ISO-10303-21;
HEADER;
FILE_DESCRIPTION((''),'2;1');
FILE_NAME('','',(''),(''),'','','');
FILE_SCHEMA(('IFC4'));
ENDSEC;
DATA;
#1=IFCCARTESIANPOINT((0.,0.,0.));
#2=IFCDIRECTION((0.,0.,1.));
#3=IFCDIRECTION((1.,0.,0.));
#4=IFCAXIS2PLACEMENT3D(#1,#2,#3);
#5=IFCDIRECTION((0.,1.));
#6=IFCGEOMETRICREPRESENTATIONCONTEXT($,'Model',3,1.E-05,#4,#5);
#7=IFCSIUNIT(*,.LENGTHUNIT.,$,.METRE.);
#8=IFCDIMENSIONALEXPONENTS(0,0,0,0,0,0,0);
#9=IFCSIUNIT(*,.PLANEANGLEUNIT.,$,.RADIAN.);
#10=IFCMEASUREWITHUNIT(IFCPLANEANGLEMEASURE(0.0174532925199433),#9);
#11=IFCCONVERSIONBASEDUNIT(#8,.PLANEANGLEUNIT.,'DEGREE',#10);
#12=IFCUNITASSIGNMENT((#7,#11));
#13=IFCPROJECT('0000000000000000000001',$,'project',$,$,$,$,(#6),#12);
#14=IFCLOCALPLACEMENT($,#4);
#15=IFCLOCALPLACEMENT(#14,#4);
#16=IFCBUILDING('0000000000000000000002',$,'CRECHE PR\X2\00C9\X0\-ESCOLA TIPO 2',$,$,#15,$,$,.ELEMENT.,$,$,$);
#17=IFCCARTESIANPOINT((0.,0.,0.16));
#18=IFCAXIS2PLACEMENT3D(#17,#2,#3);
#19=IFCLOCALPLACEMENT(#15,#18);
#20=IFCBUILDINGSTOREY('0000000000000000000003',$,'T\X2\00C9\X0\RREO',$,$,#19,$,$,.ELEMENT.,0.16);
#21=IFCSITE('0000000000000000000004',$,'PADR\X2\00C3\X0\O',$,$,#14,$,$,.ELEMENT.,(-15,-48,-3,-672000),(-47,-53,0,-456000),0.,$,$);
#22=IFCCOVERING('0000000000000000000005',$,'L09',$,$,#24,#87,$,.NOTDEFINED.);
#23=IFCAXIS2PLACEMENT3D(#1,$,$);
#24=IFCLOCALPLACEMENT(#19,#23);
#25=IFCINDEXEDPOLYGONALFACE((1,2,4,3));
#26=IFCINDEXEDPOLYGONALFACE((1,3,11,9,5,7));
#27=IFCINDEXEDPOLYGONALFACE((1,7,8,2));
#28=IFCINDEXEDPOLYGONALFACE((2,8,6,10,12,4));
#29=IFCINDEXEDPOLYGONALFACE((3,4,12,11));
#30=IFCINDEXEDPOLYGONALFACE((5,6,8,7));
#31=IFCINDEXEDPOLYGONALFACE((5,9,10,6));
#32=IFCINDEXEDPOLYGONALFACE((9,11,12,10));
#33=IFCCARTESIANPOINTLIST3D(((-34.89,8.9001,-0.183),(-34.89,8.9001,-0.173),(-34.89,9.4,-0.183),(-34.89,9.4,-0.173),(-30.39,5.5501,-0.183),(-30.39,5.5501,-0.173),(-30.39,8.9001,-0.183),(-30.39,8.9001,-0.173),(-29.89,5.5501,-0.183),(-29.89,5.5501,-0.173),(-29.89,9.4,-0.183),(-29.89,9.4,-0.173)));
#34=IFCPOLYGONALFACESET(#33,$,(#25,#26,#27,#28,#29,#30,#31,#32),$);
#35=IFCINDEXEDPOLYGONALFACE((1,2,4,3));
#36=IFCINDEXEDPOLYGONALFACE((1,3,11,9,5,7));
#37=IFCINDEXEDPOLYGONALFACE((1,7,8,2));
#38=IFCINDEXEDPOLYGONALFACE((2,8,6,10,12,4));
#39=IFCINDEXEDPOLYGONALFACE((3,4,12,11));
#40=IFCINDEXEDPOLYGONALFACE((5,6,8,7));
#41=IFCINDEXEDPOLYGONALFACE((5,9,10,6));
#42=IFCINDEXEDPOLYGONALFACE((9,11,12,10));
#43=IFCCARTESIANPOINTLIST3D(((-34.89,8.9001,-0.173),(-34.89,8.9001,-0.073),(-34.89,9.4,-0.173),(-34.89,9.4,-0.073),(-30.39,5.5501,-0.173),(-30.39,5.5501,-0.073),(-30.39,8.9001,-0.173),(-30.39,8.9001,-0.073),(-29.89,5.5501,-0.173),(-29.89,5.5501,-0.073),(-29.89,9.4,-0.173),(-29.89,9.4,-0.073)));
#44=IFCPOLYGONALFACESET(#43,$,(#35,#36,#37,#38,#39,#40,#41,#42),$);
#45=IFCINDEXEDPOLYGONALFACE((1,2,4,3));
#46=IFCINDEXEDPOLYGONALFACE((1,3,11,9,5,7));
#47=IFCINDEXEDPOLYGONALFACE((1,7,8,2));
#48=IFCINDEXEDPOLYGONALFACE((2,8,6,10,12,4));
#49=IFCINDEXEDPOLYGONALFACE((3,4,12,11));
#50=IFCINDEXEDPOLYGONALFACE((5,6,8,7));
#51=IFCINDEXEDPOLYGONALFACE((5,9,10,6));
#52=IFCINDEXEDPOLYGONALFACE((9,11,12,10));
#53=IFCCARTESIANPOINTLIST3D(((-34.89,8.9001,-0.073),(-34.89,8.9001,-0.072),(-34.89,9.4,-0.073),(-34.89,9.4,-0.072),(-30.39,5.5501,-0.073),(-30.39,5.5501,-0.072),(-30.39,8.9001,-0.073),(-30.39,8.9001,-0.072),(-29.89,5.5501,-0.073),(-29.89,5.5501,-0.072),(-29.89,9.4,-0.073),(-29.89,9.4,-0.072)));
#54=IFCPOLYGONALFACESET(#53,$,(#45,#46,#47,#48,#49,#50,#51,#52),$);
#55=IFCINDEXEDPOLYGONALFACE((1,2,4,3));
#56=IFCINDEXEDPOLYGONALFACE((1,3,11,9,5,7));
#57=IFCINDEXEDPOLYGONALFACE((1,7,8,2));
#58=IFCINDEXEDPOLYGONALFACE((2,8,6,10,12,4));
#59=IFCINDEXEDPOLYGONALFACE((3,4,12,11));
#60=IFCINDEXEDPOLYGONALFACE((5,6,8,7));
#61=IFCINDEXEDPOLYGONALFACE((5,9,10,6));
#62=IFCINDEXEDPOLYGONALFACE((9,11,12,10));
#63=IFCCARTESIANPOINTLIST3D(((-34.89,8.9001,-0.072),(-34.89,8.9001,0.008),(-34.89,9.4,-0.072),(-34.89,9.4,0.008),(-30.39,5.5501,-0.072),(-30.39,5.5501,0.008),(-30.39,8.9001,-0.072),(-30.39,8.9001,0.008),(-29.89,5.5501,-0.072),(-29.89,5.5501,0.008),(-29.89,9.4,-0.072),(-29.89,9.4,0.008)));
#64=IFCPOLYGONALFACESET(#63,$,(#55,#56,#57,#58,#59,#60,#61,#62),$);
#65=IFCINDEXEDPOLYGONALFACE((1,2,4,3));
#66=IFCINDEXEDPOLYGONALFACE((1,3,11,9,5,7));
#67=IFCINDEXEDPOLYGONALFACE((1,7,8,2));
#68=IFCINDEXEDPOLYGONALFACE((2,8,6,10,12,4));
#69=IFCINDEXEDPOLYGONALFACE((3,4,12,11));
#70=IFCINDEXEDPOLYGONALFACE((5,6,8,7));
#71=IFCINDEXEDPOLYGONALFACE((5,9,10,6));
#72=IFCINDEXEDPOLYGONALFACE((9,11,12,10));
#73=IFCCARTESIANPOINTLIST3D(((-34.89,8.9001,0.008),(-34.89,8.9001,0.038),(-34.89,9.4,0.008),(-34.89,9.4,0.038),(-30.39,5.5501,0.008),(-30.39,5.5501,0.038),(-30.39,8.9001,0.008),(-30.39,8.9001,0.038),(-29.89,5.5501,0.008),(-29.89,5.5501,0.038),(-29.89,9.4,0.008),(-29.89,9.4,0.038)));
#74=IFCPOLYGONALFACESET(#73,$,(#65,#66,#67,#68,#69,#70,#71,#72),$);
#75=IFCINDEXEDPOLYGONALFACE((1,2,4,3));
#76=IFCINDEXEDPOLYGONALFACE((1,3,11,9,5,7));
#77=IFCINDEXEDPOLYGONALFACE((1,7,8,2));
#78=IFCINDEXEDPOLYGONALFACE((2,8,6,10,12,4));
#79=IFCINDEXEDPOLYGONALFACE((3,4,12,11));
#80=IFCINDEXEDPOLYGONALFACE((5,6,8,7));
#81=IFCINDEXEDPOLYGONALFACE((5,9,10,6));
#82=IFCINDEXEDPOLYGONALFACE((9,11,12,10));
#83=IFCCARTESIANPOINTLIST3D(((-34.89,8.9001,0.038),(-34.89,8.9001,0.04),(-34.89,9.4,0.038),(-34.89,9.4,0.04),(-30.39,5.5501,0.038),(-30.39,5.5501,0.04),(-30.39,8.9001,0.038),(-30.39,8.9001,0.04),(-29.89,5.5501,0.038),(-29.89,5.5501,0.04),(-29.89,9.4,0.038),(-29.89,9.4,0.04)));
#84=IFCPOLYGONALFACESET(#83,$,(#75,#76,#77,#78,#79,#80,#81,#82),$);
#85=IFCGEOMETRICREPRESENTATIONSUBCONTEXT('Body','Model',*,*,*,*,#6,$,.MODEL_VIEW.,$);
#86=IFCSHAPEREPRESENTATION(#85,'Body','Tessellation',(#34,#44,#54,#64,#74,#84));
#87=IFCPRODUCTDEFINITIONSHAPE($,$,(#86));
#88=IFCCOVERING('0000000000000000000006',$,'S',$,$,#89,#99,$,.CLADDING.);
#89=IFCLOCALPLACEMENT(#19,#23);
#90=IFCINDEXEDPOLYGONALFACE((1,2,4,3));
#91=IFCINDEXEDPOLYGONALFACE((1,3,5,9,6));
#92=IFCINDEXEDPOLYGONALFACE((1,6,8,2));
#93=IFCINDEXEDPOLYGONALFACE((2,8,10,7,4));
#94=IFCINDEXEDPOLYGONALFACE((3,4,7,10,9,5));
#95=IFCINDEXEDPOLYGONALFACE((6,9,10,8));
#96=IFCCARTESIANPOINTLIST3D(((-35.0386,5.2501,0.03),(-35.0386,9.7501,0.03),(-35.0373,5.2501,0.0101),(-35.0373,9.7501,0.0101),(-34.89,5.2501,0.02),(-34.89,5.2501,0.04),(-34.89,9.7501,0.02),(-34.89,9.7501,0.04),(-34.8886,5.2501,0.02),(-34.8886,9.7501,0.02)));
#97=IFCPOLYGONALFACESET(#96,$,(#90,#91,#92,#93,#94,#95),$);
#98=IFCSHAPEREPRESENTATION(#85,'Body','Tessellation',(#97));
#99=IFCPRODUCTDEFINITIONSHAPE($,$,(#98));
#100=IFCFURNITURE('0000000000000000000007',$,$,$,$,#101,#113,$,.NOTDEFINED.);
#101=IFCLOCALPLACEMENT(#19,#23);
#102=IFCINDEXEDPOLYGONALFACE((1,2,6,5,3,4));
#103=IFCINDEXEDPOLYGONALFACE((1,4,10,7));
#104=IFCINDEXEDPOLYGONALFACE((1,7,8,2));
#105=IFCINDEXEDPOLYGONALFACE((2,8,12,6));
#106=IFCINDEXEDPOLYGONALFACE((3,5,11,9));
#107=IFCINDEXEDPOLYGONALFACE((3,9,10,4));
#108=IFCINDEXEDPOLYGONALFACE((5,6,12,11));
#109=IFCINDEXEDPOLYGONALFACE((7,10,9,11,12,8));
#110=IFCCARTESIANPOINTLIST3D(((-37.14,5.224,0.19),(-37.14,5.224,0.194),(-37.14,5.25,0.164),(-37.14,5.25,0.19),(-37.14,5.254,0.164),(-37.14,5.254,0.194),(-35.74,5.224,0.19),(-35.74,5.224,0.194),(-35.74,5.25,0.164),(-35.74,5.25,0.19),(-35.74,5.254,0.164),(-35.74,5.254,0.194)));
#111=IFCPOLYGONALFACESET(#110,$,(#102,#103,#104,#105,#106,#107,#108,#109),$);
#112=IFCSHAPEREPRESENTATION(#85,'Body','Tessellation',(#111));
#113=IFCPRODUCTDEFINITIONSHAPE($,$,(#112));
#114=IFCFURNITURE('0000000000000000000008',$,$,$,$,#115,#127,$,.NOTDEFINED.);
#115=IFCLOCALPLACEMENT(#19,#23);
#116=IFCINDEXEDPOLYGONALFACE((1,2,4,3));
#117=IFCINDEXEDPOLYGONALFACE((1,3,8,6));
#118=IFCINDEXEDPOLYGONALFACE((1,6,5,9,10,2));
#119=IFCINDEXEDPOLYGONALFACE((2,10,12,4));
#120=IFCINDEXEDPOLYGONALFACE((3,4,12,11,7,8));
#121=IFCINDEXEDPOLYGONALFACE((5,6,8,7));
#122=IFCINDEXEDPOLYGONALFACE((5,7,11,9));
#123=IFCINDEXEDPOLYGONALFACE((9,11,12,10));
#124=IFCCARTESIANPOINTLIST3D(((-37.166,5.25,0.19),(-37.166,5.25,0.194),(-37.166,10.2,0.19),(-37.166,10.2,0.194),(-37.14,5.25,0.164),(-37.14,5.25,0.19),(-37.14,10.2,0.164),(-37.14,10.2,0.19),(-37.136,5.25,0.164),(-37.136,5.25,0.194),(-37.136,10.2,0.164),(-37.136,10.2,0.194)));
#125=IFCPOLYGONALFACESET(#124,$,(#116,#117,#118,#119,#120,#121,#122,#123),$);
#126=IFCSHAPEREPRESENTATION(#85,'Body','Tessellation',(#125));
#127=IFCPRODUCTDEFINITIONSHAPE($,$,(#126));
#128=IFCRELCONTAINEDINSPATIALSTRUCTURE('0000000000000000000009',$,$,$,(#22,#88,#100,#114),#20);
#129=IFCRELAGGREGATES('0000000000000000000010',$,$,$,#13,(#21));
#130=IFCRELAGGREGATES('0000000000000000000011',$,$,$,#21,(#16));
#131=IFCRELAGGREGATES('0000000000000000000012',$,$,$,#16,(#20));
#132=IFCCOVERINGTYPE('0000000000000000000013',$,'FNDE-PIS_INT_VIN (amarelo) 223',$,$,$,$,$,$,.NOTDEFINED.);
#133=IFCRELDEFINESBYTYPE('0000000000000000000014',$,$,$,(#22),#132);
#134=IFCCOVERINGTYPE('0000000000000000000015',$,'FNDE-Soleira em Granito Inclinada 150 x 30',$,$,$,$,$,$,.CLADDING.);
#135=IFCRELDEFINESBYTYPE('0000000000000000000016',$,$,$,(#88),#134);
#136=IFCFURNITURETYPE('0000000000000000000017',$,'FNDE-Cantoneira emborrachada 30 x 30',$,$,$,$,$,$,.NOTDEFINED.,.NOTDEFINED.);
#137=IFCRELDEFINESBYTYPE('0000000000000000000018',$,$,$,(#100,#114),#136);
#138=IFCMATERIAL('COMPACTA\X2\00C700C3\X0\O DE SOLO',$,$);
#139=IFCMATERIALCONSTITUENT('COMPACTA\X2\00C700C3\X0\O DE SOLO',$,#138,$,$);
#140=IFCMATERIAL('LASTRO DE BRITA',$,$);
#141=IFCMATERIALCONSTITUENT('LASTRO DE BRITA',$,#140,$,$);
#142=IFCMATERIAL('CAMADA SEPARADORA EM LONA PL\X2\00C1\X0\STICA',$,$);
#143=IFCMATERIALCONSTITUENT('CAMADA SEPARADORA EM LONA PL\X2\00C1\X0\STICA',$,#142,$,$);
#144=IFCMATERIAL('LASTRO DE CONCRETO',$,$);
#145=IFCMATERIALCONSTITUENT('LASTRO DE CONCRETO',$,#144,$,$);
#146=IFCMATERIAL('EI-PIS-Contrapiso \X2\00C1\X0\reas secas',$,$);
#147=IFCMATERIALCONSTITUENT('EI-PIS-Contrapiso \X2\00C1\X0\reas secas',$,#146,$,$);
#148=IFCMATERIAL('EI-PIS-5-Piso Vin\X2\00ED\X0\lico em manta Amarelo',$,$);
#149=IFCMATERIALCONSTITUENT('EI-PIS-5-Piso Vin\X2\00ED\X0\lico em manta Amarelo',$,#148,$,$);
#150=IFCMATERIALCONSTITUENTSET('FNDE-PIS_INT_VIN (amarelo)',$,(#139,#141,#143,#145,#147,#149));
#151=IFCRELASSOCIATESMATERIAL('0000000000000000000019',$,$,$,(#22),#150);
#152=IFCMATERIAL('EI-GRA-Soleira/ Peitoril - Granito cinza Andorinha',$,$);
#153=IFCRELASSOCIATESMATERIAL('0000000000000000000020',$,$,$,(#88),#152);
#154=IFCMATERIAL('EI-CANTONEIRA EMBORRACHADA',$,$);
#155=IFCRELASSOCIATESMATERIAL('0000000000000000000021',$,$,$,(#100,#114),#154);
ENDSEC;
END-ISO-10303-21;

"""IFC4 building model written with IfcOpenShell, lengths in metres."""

from ifc_helpers import new_model, entity, si_unit, converted_unit, direction, frame, origin_with_axes, place, context, subcontext, project, spatial, line, indexed_curve, outline, extrude, material, constituent, constituent_set, material_profile, profile_set, type_object, element, save


model = new_model("IFC4")

# Units and contexts
model_context = context("Model", 3, precision=1e-05, world=origin_with_axes(), true_north=direction((0.0, 1.0)))
body_context = subcontext(model_context, "Body", "Model", "MODEL_VIEW")
ifc_project = project(units=[si_unit("LENGTHUNIT", "METRE"), converted_unit("PLANEANGLEUNIT", "DEGREE", entity("IfcPlaneAngleMeasure", 0.0174532925199433), si_unit("PLANEANGLEUNIT", "RADIAN"), dimensions=[0, 0, 0, 0, 0, 0, 0])], contexts=[model_context])

# Site, building, storey
site_placement = place(None, origin_with_axes())
site = spatial("IfcSite", under=ifc_project, at=site_placement, Name="PADRÃO", CompositionType="ELEMENT", RefLatitude=(-15, -48, -3, -672000), RefLongitude=(-47, -53, 0, -456000), RefElevation=0.0)
building_placement = place(site_placement, origin_with_axes())
building = spatial("IfcBuilding", under=site, at=building_placement, Name="CRECHE PRÉ-ESCOLA TIPO 2", CompositionType="ELEMENT")
storey_placement = place(building_placement, frame((0.0, 0.0, 0.16), z_axis=(0.0, 0.0, 1.0), x_axis=(1.0, 0.0, 0.0)))
storey = spatial("IfcBuildingStorey", under=building, at=storey_placement, Name="TÉRREO", CompositionType="ELEMENT", Elevation=0.16)

# Coverings
ifc_material_1 = material(Name="COMPACTAÇÃO DE SOLO")
ifc_material_2 = material(Name="LASTRO DE BRITA")
ifc_material_3 = material(Name="CAMADA SEPARADORA EM LONA PLÁSTICA")
ifc_material_4 = material(Name="LASTRO DE CONCRETO")
ifc_material_5 = material(Name="EI-PIS-Contrapiso Áreas secas")
ifc_constituent_1 = constituent(ifc_material_1, Name="COMPACTAÇÃO DE SOLO")
ifc_constituent_2 = constituent(ifc_material_2, Name="LASTRO DE BRITA")
ifc_constituent_3 = constituent(ifc_material_3, Name="CAMADA SEPARADORA EM LONA PLÁSTICA")
ifc_constituent_4 = constituent(ifc_material_4, Name="LASTRO DE CONCRETO")
ifc_constituent_5 = constituent(ifc_material_5, Name="EI-PIS-Contrapiso Áreas secas")
ifc_material_6 = material(Name="EI-PIS-5-Piso Vinílico em manta Amarelo")
ifc_constituent_6 = constituent(ifc_material_6, Name="EI-PIS-5-Piso Vinílico em manta Amarelo")
ifc_constituent_set_1 = constituent_set(constituents=[ifc_constituent_1, ifc_constituent_2, ifc_constituent_3, ifc_constituent_4, ifc_constituent_5, ifc_constituent_6], Name="FNDE-PIS_INT_VIN (amarelo)")
covering_type_1 = type_object("IfcCoveringType", Name="FNDE-PIS_INT_VIN (amarelo) 223", PredefinedType="NOTDEFINED")
covering_1_placement = place(storey_placement, frame((-34.89, 9.4, 0.04), z_axis=(0.0, 0.0, 1.0), x_axis=(1.0, 0.0, 0.0)))
element("IfcCovering", 1, at=covering_1_placement, inside=storey, type_object=covering_type_1, material=ifc_constituent_set_1, Name="L09", PredefinedType="NOTDEFINED", context=body_context, shape_type="SweptSolid", body=[
    extrude(outline(indexed_curve([(0.0, 0.0), (0.0, -0.4999), (4.4999, -0.4999), (4.4999, -3.8499), (4.9999, -3.8499), (4.9999, 0.0)], segments=[line(1, 2, 3, 4, 5, 6, 1)])), frame((0.0, 0.0, -0.223), z_axis=(0.0, 0.0, 1.0), x_axis=(1.0, 0.0, 0.0)), (0.0, 0.0, 1.0), 0.01),
    extrude(outline(indexed_curve([(0.0, 0.0), (0.0, -0.4999), (4.4999, -0.4999), (4.4999, -3.8499), (4.9999, -3.8499), (4.9999, 0.0)], segments=[line(1, 2, 3, 4, 5, 6, 1)])), frame((0.0, 0.0, -0.213), z_axis=(0.0, 0.0, 1.0), x_axis=(1.0, 0.0, 0.0)), (0.0, 0.0, 1.0), 0.1),
    extrude(outline(indexed_curve([(0.0, 0.0), (0.0, -0.4999), (4.4999, -0.4999), (4.4999, -3.8499), (4.9999, -3.8499), (4.9999, 0.0)], segments=[line(1, 2, 3, 4, 5, 6, 1)])), frame((0.0, 0.0, -0.113), z_axis=(0.0, 0.0, 1.0), x_axis=(1.0, 0.0, 0.0)), (0.0, 0.0, 1.0), 0.001),
    extrude(outline(indexed_curve([(0.0, 0.0), (0.0, -0.4999), (4.4999, -0.4999), (4.4999, -3.8499), (4.9999, -3.8499), (4.9999, 0.0)], segments=[line(1, 2, 3, 4, 5, 6, 1)])), frame((0.0, 0.0, -0.112), z_axis=(0.0, 0.0, 1.0), x_axis=(1.0, 0.0, 0.0)), (0.0, 0.0, 1.0), 0.08),
    extrude(outline(indexed_curve([(0.0, 0.0), (0.0, -0.4999), (4.4999, -0.4999), (4.4999, -3.8499), (4.9999, -3.8499), (4.9999, 0.0)], segments=[line(1, 2, 3, 4, 5, 6, 1)])), frame((0.0, 0.0, -0.032), z_axis=(0.0, 0.0, 1.0), x_axis=(1.0, 0.0, 0.0)), (0.0, 0.0, 1.0), 0.03),
    extrude(outline(indexed_curve([(0.0, 0.0), (0.0, -0.4999), (4.4999, -0.4999), (4.4999, -3.8499), (4.9999, -3.8499), (4.9999, 0.0)], segments=[line(1, 2, 3, 4, 5, 6, 1)])), frame((0.0, 0.0, -0.002), z_axis=(0.0, 0.0, 1.0), x_axis=(1.0, 0.0, 0.0)), (0.0, 0.0, 1.0), 0.002),
])
ifc_material_7 = material(Name="EI-GRA-Soleira/ Peitoril - Granito cinza Andorinha")
ifc_material_profile_1 = material_profile(ifc_material_7, outline(indexed_curve([(-0.0013, 0.02), (0.0, 0.02), (0.1474, 0.0101), (0.1487, 0.03), (0.0, 0.04)], segments=[line(1, 2, 3, 4, 5, 1)])), Name="EI-GRA-Soleira/ Peitoril - Granito cinza Andorinha")
ifc_profile_set_1 = profile_set([ifc_material_profile_1], Name="FNDE-Soleira em Granito Inclinada")
covering_type_2 = type_object("IfcCoveringType", Name="FNDE-Soleira em Granito Inclinada 150 x 30", PredefinedType="CLADDING")
covering_2_placement = place(storey_placement, frame((-34.89, 9.7501, 0.0), z_axis=(0.0, 0.0, 1.0), x_axis=(-1.0, 0.0, 0.0)))
element("IfcCovering", 2, at=covering_2_placement, inside=storey, type_object=covering_type_2, material=ifc_profile_set_1, Name="S", PredefinedType="CLADDING", context=body_context, shape_type="SweptSolid", body=[
    extrude(outline(indexed_curve([(-0.0013, 0.02), (0.0, 0.02), (0.1474, 0.0101), (0.1487, 0.03), (0.0, 0.04)], segments=[line(1, 2, 3, 4, 5, 1)])), frame((0.0, 4.5, 0.0), z_axis=(0.0, -1.0, 0.0), x_axis=(1.0, 0.0, 0.0)), (0.0, 0.0, 1.0), 4.5),
])

# Furniture
ifc_material_8 = material(Name="EI-CANTONEIRA EMBORRACHADA")
ifc_material_profile_2 = material_profile(ifc_material_8, outline(indexed_curve([(-0.004, 0.004), (-0.004, -0.026), (0.0, -0.026), (0.0, 0.0), (0.026, 0.0), (0.026, 0.004)], segments=[line(1, 2, 3, 4, 5, 6, 1)])), Name="EI-CANTONEIRA EMBORRACHADA")
ifc_profile_set_2 = profile_set([ifc_material_profile_2], Name="FNDE-Cantoneira emborrachada")
furniture_type = type_object("IfcFurnitureType", Name="FNDE-Cantoneira emborrachada 30 x 30", AssemblyPlace="NOTDEFINED", PredefinedType="NOTDEFINED")
furniture_1_placement = place(storey_placement, frame((-37.14, 5.25, 0.19), z_axis=(0.0, 0.0, 1.0), x_axis=(0.0, -1.0, 0.0)))
element("IfcFurniture", 3, at=furniture_1_placement, inside=storey, type_object=furniture_type, material=ifc_profile_set_2, PredefinedType="NOTDEFINED", context=body_context, shape_type="SweptSolid", body=[
    extrude(outline(indexed_curve([(-0.004, 0.004), (-0.004, -0.026), (0.0, -0.026), (0.0, 0.0), (0.026, 0.0), (0.026, 0.004)], segments=[line(1, 2, 3, 4, 5, 6, 1)])), frame((0.0, 1.4, 0.0), z_axis=(0.0, -1.0, 0.0), x_axis=(1.0, 0.0, 0.0)), (0.0, 0.0, 1.0), 1.4),
])
furniture_2_placement = place(storey_placement, frame((-37.14, 10.2, 0.19), z_axis=(0.0, 0.0, 1.0), x_axis=(-1.0, 0.0, 0.0)))
element("IfcFurniture", 4, at=furniture_2_placement, inside=storey, type_object=furniture_type, material=ifc_profile_set_2, PredefinedType="NOTDEFINED", context=body_context, shape_type="SweptSolid", body=[
    extrude(outline(indexed_curve([(-0.004, 0.004), (-0.004, -0.026), (0.0, -0.026), (0.0, 0.0), (0.026, 0.0), (0.026, 0.004)], segments=[line(1, 2, 3, 4, 5, 6, 1)])), frame((0.0, 4.95, 0.0), z_axis=(0.0, -1.0, 0.0), x_axis=(1.0, 0.0, 0.0)), (0.0, 0.0, 1.0), 4.95),
])

save(model, "model.ifc")
